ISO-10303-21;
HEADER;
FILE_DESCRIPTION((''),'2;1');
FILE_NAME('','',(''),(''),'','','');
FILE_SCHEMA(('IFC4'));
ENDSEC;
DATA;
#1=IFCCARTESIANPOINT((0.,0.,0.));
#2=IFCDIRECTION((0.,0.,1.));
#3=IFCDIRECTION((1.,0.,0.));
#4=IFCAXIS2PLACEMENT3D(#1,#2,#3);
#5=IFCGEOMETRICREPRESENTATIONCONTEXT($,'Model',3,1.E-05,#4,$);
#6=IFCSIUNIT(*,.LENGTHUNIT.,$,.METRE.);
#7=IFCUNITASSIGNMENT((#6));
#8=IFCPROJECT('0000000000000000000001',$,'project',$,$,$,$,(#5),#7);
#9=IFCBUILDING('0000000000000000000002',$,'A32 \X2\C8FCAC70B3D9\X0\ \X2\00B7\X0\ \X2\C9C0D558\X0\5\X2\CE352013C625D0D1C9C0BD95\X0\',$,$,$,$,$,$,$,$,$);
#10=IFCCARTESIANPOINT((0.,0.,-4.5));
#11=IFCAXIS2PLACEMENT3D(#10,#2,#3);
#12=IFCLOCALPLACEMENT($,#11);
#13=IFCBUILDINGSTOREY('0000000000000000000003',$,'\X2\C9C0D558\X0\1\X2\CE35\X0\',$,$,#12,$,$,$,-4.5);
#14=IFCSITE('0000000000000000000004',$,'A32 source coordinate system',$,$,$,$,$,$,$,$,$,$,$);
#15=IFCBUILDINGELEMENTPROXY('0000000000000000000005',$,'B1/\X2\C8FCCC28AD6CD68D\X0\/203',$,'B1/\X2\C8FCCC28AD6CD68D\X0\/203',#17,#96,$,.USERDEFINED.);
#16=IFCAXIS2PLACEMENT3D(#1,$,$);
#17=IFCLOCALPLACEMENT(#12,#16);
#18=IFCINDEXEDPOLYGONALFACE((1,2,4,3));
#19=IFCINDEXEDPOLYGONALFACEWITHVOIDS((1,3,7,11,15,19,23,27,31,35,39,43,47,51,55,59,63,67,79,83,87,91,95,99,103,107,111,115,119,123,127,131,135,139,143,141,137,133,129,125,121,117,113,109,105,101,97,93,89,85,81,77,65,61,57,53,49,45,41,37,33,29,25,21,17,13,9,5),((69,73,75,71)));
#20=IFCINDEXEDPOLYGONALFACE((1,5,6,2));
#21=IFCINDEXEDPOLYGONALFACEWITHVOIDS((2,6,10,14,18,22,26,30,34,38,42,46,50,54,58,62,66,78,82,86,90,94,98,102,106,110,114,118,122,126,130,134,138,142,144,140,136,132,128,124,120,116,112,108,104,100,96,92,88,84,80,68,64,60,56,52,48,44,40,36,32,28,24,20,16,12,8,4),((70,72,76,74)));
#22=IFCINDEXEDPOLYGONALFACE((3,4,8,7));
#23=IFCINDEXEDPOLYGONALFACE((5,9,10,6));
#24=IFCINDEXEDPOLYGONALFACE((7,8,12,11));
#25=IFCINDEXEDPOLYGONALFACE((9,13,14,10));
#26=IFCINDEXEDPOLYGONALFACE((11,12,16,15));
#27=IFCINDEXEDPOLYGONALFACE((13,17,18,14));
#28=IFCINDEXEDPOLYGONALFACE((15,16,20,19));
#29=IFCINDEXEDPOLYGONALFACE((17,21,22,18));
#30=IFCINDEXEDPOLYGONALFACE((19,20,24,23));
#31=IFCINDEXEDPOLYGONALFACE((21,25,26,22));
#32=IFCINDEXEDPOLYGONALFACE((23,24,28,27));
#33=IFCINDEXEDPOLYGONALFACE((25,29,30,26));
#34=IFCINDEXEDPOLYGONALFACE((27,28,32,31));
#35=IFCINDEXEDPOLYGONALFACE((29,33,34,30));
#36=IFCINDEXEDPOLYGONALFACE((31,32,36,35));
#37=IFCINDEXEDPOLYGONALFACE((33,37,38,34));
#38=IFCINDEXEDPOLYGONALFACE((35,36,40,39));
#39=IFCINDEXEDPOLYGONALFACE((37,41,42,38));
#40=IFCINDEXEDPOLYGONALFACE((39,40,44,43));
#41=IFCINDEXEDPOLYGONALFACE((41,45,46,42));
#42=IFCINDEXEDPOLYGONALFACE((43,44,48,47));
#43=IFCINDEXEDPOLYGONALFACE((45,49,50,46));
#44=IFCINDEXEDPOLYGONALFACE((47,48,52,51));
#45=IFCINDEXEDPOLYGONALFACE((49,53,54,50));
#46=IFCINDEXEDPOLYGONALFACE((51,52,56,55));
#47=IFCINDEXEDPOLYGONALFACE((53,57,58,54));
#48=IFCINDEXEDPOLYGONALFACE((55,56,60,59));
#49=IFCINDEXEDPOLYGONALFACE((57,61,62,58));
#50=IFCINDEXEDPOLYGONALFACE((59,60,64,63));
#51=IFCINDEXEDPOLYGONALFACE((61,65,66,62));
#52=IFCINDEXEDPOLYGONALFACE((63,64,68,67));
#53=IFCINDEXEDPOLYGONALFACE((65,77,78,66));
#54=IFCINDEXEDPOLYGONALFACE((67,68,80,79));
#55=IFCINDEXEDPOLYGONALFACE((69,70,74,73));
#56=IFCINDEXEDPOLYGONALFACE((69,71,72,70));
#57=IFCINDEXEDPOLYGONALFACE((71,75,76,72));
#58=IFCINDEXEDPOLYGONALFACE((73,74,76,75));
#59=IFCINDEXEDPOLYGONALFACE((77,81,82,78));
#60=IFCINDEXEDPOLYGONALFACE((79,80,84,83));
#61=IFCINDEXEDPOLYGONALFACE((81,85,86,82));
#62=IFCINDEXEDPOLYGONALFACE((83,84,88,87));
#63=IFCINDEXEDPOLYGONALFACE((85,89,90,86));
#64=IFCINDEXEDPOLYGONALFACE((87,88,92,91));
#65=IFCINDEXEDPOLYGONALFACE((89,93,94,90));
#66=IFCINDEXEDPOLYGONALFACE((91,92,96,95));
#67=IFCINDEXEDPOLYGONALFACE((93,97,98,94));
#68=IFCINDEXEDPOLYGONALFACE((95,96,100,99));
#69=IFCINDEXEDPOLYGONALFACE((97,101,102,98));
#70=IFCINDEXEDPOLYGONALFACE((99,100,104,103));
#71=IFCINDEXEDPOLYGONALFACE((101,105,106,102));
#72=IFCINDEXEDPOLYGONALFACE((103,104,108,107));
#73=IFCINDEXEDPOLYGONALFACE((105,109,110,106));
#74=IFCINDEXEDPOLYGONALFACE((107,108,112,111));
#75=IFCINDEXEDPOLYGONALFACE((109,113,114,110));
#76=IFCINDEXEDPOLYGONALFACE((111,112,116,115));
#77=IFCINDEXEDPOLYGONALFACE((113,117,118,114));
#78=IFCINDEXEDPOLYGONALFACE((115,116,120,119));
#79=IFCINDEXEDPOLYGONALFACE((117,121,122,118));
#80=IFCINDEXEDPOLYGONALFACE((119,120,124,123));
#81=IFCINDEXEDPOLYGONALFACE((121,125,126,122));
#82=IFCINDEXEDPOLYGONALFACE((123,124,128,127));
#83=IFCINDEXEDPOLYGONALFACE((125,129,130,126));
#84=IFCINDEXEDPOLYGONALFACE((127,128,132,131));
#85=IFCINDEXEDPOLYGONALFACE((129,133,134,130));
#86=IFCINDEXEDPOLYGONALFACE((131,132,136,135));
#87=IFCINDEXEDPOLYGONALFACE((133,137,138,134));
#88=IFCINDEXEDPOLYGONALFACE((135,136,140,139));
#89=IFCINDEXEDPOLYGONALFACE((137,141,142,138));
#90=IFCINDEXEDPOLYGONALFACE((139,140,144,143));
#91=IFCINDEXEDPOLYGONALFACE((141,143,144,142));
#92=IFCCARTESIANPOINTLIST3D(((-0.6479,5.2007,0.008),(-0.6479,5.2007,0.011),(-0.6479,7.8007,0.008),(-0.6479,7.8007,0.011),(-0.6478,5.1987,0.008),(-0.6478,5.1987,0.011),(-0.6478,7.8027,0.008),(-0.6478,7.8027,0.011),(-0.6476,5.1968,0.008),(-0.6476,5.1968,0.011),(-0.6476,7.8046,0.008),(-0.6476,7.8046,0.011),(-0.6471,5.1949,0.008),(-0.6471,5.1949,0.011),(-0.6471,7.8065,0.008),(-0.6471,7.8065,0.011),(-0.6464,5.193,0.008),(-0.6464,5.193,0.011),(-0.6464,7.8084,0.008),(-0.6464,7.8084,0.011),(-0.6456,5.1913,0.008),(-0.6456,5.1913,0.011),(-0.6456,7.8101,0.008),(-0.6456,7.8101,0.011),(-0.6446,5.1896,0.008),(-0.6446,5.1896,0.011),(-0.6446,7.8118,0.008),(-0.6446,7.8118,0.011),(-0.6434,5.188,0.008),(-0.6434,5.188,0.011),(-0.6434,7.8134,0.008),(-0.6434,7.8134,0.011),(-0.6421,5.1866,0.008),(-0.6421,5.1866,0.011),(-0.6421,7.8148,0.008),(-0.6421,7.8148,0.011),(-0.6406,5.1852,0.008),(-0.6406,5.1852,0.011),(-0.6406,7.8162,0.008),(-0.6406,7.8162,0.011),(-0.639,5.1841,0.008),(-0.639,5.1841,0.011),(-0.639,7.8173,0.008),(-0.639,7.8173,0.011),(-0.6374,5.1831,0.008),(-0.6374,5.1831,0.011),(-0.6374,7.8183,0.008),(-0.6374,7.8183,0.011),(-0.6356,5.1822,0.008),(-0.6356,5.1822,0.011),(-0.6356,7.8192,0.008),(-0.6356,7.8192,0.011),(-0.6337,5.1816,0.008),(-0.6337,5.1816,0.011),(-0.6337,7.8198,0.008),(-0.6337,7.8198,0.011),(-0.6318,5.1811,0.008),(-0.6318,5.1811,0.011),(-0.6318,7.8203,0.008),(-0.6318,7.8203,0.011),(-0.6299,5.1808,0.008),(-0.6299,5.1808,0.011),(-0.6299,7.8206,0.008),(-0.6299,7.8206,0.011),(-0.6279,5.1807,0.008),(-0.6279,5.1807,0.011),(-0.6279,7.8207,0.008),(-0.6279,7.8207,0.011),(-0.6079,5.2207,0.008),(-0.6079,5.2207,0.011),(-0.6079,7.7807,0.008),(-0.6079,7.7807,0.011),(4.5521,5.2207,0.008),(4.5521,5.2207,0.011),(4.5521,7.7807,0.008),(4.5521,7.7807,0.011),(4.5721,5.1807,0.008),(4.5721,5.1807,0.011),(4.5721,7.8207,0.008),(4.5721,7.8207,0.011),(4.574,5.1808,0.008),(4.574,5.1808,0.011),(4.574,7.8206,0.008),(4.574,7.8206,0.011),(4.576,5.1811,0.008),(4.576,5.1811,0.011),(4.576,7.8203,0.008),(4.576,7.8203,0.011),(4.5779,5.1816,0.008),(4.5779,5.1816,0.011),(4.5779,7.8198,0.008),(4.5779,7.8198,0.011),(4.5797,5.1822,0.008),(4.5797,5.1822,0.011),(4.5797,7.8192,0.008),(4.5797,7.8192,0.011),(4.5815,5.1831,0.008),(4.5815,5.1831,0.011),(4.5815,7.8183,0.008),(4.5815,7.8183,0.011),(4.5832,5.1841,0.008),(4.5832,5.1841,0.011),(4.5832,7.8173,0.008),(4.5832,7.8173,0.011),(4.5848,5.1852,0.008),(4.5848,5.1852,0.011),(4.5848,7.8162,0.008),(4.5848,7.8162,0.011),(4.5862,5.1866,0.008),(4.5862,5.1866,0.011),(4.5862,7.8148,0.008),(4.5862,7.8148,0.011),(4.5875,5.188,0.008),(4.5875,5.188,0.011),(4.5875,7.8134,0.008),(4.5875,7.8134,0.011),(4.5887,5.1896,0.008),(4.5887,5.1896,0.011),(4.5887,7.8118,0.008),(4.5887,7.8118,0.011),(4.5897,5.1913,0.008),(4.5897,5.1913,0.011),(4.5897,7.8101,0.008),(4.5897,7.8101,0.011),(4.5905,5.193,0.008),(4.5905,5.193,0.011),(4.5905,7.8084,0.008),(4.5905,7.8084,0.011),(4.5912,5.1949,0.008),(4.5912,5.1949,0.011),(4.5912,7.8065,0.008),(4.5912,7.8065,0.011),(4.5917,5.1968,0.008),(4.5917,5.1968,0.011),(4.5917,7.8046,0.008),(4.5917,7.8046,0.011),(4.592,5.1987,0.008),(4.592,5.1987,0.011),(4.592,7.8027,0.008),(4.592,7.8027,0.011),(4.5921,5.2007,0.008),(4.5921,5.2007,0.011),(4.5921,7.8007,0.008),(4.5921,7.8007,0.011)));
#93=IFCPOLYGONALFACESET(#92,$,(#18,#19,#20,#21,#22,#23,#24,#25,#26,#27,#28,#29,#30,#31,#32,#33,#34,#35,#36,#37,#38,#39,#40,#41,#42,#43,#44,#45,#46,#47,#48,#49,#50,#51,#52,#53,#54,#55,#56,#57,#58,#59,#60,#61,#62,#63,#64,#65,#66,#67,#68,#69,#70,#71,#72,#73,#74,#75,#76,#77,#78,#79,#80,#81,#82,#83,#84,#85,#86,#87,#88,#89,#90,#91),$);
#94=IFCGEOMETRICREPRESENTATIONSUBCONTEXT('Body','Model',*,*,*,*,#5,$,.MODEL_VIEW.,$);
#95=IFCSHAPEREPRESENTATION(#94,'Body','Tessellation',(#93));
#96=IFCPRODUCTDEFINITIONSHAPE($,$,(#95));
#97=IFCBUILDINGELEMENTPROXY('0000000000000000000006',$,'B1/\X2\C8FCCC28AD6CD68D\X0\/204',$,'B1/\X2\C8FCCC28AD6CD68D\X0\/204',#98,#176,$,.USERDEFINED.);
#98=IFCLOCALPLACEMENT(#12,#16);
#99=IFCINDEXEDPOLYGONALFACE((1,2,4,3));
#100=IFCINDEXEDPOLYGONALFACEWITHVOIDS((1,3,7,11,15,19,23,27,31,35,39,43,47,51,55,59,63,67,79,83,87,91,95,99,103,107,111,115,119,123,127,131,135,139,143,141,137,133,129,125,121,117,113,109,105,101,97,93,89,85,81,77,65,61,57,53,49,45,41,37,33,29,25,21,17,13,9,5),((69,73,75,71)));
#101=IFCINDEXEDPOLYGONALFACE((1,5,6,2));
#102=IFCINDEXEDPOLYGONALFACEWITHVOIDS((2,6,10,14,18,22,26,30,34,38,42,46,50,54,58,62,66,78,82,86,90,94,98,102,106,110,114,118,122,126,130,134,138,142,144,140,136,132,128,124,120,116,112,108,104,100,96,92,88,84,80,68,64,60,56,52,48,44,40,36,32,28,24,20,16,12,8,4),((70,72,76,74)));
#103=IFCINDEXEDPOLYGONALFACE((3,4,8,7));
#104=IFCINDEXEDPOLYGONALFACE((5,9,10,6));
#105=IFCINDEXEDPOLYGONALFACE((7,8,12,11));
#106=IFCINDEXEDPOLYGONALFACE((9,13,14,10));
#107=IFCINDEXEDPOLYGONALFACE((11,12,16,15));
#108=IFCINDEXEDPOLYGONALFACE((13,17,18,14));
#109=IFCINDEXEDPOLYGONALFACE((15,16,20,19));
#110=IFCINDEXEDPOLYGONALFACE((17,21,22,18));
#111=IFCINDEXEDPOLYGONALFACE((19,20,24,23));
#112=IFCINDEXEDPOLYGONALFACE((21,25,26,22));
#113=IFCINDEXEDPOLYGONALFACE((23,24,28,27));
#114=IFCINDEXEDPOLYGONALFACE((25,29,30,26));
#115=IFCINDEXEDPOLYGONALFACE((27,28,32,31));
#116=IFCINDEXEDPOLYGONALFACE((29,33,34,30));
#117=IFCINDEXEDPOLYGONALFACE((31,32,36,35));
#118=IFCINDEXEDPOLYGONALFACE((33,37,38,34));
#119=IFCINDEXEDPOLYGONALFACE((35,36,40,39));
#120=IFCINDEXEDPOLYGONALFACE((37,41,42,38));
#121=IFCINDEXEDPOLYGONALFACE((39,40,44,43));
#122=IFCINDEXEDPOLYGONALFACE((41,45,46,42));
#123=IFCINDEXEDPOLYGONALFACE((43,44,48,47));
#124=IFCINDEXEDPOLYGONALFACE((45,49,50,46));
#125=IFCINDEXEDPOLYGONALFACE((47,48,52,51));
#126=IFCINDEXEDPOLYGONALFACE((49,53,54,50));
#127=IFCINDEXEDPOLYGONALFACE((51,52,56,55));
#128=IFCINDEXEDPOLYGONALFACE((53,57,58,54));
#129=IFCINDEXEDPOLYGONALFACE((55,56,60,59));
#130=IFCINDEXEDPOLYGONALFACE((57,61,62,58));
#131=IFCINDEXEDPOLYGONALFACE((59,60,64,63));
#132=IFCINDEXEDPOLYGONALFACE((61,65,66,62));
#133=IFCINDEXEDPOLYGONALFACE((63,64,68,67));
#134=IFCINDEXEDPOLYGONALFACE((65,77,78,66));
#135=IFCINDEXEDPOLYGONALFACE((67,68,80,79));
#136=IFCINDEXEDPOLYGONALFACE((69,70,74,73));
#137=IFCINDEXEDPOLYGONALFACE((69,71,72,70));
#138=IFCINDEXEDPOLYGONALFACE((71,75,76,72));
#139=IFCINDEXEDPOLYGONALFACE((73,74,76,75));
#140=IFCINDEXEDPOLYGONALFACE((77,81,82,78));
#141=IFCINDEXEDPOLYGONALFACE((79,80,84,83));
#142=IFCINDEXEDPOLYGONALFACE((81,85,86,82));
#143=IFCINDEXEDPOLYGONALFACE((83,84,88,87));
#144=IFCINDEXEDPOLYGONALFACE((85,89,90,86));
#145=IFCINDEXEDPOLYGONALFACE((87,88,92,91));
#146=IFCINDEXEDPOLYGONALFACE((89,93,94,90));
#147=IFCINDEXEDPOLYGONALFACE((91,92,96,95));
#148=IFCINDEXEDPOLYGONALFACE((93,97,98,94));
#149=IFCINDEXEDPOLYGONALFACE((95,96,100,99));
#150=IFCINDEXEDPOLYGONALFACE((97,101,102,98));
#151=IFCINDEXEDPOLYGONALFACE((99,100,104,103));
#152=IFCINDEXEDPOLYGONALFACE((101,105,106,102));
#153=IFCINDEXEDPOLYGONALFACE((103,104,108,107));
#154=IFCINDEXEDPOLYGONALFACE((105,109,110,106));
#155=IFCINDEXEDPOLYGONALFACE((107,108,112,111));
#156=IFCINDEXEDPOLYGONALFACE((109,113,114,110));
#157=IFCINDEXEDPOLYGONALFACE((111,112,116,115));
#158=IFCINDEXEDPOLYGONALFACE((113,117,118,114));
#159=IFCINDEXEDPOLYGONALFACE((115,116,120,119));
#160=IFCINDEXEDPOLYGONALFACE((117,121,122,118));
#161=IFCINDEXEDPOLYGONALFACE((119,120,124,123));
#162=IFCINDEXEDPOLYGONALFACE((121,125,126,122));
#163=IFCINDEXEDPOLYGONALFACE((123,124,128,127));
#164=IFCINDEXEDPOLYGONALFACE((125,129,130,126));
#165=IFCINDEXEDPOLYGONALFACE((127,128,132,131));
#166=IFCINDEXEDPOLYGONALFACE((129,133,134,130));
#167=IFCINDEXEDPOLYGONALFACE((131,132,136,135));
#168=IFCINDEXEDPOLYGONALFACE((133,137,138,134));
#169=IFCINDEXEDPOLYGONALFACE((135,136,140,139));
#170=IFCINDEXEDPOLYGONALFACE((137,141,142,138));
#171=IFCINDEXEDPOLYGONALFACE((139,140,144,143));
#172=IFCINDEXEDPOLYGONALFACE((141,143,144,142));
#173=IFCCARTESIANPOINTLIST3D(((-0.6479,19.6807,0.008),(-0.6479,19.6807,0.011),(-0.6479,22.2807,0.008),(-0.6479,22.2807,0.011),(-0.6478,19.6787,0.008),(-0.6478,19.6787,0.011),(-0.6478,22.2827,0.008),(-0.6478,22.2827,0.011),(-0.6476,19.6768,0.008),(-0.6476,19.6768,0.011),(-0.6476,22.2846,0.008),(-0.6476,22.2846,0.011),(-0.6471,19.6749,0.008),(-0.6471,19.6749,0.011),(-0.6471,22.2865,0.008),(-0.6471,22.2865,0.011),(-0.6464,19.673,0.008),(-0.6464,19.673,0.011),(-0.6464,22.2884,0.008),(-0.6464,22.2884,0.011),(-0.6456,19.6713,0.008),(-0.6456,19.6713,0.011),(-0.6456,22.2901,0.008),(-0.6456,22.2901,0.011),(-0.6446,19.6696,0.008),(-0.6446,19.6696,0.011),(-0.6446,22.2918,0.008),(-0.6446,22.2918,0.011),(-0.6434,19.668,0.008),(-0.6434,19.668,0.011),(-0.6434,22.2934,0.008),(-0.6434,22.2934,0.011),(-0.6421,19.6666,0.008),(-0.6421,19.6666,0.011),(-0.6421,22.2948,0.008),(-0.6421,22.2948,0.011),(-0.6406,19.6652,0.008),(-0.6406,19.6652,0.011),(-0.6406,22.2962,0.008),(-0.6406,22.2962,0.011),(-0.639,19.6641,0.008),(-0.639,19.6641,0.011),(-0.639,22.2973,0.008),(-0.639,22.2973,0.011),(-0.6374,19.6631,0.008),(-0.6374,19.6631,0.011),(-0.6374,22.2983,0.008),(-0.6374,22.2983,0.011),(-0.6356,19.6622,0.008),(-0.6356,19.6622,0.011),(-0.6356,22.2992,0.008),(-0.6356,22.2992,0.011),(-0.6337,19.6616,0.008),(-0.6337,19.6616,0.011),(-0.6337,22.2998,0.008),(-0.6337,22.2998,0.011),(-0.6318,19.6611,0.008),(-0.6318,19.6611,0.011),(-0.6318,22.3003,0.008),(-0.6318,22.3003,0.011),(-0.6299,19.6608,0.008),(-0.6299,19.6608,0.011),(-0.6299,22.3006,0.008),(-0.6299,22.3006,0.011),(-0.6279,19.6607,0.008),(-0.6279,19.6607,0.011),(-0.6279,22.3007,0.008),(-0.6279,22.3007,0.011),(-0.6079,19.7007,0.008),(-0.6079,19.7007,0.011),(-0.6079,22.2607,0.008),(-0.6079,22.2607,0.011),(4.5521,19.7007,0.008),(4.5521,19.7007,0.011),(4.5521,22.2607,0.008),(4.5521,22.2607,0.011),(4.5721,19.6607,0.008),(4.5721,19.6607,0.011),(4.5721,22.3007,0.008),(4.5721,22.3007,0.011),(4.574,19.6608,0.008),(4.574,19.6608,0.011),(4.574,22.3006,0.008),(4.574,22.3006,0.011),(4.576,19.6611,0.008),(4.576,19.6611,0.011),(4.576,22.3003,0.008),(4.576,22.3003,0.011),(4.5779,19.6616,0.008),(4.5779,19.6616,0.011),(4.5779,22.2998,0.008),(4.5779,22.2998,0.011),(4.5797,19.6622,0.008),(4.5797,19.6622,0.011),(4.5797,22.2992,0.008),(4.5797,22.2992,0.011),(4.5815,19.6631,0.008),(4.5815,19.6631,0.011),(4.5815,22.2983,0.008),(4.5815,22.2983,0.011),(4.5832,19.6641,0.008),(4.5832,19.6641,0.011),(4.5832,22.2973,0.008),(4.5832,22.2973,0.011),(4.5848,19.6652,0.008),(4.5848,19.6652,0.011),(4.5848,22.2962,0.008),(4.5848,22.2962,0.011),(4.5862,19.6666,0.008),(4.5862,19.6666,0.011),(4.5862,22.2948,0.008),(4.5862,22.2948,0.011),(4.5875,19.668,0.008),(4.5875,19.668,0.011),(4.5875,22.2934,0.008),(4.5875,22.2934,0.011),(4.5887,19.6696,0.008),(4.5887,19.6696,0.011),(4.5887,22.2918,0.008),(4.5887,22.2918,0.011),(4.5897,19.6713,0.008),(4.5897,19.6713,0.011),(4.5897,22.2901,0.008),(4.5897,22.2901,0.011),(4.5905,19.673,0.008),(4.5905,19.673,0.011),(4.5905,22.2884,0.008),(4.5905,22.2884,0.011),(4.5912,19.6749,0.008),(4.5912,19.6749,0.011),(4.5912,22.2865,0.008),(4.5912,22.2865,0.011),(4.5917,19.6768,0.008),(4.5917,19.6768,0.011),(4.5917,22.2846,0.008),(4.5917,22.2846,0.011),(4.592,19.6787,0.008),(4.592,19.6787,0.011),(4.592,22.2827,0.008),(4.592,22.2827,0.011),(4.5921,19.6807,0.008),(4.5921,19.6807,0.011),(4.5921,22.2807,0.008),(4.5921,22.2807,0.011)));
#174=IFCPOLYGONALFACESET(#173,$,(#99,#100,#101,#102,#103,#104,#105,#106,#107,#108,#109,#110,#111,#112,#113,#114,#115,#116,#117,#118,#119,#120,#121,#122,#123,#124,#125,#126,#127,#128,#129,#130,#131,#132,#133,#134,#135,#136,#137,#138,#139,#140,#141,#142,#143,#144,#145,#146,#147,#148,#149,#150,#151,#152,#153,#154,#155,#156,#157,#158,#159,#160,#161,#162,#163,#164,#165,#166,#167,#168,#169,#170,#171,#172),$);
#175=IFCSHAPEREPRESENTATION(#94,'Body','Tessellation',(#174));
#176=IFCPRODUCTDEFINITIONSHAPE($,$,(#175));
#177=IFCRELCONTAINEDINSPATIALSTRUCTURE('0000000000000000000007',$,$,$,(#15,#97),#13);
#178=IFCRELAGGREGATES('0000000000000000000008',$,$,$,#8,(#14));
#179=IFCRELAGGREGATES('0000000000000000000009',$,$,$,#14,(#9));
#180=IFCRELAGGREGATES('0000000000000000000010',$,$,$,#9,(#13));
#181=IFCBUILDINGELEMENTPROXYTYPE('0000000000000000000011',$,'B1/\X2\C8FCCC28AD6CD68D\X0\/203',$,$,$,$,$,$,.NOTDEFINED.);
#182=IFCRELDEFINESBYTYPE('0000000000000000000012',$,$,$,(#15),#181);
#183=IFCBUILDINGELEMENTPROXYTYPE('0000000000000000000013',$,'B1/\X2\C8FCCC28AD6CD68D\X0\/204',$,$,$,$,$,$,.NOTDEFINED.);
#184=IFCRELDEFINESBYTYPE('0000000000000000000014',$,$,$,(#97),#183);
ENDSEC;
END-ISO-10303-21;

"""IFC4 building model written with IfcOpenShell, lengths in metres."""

from ifc_helpers import new_model, si_unit, frame, origin, origin_with_axes, place, context, subcontext, project, spatial, polyline, outline, extrude, source, transform, mapped, type_object, type_shapes, element, save


model = new_model("IFC4")

# Units and contexts
model_context = context("Model", 3, precision=1e-05, world=origin_with_axes())
body_context = subcontext(model_context, "Body", "Model", "MODEL_VIEW")
ifc_project = project(units=[si_unit("LENGTHUNIT", "METRE")], contexts=[model_context])

# Site, building, storey
site = spatial("IfcSite", under=ifc_project, Name="A32 source coordinate system")
building = spatial("IfcBuilding", under=site, Name="A32 주거동 · 지하5층–옥탑지붕")
storey_placement = place(None, frame((0.0, 0.0, -4.5), z_axis=(0.0, 0.0, 1.0), x_axis=(1.0, 0.0, 0.0)))
storey = spatial("IfcBuildingStorey", under=building, at=storey_placement, Name="지하1층", Elevation=-4.5)

# Building element proxies
building_element_proxy_type_1 = type_object("IfcBuildingElementProxyType", Name="B1/주차구획/203", PredefinedType="NOTDEFINED")
shared_shape_1 = source(origin(), body_context, "Body", "SweptSolid", [
    extrude(outline(polyline([(-0.6279, 5.1807), (-0.6299, 5.1808), (-0.6318, 5.1811), (-0.6337, 5.1816), (-0.6356, 5.1822), (-0.6374, 5.1831), (-0.639, 5.1841), (-0.6406, 5.1852), (-0.6421, 5.1866), (-0.6434, 5.188), (-0.6446, 5.1896), (-0.6456, 5.1913), (-0.6464, 5.193), (-0.6471, 5.1949), (-0.6476, 5.1968), (-0.6478, 5.1987), (-0.6479, 5.2007), (-0.6479, 7.8007), (-0.6478, 7.8027), (-0.6476, 7.8046), (-0.6471, 7.8065), (-0.6464, 7.8084), (-0.6456, 7.8101), (-0.6446, 7.8118), (-0.6434, 7.8134), (-0.6421, 7.8148), (-0.6406, 7.8162), (-0.639, 7.8173), (-0.6374, 7.8183), (-0.6356, 7.8192), (-0.6337, 7.8198), (-0.6318, 7.8203), (-0.6299, 7.8206), (-0.6279, 7.8207), (4.5721, 7.8207), (4.574, 7.8206), (4.576, 7.8203), (4.5779, 7.8198), (4.5797, 7.8192), (4.5815, 7.8183), (4.5832, 7.8173), (4.5848, 7.8162), (4.5862, 7.8148), (4.5875, 7.8134), (4.5887, 7.8118), (4.5897, 7.8101), (4.5905, 7.8084), (4.5912, 7.8065), (4.5917, 7.8046), (4.592, 7.8027), (4.5921, 7.8007), (4.5921, 5.2007), (4.592, 5.1987), (4.5917, 5.1968), (4.5912, 5.1949), (4.5905, 5.193), (4.5897, 5.1913), (4.5887, 5.1896), (4.5875, 5.188), (4.5862, 5.1866), (4.5848, 5.1852), (4.5832, 5.1841), (4.5815, 5.1831), (4.5797, 5.1822), (4.5779, 5.1816), (4.576, 5.1811), (4.574, 5.1808), (4.5721, 5.1807), (-0.6279, 5.1807)]), holes=[polyline([(-0.6079, 5.2207), (4.5521, 5.2207), (4.5521, 7.7807), (-0.6079, 7.7807), (-0.6079, 5.2207)])]), frame((0.0, 0.0, 0.008)), (0.0, 0.0, 1.0), 0.003),
])
type_shapes(building_element_proxy_type_1, [shared_shape_1])
proxy_1_placement = place(storey_placement, origin_with_axes())
element("IfcBuildingElementProxy", 1, at=proxy_1_placement, inside=storey, type_object=building_element_proxy_type_1, Name="B1/주차구획/203", ObjectType="B1/주차구획/203", PredefinedType="USERDEFINED", context=body_context, shape_type="MappedRepresentation", body=[
    mapped(shared_shape_1, transform((0.0, 0.0, 0.0), scale=1.0)),
])
building_element_proxy_type_2 = type_object("IfcBuildingElementProxyType", Name="B1/주차구획/204", PredefinedType="NOTDEFINED")
shared_shape_2 = source(origin(), body_context, "Body", "SweptSolid", [
    extrude(outline(polyline([(-0.6279, 19.6607), (-0.6299, 19.6608), (-0.6318, 19.6611), (-0.6337, 19.6616), (-0.6356, 19.6622), (-0.6374, 19.6631), (-0.639, 19.6641), (-0.6406, 19.6652), (-0.6421, 19.6666), (-0.6434, 19.668), (-0.6446, 19.6696), (-0.6456, 19.6713), (-0.6464, 19.673), (-0.6471, 19.6749), (-0.6476, 19.6768), (-0.6478, 19.6787), (-0.6479, 19.6807), (-0.6479, 22.2807), (-0.6478, 22.2827), (-0.6476, 22.2846), (-0.6471, 22.2865), (-0.6464, 22.2884), (-0.6456, 22.2901), (-0.6446, 22.2918), (-0.6434, 22.2934), (-0.6421, 22.2948), (-0.6406, 22.2962), (-0.639, 22.2973), (-0.6374, 22.2983), (-0.6356, 22.2992), (-0.6337, 22.2998), (-0.6318, 22.3003), (-0.6299, 22.3006), (-0.6279, 22.3007), (4.5721, 22.3007), (4.574, 22.3006), (4.576, 22.3003), (4.5779, 22.2998), (4.5797, 22.2992), (4.5815, 22.2983), (4.5832, 22.2973), (4.5848, 22.2962), (4.5862, 22.2948), (4.5875, 22.2934), (4.5887, 22.2918), (4.5897, 22.2901), (4.5905, 22.2884), (4.5912, 22.2865), (4.5917, 22.2846), (4.592, 22.2827), (4.5921, 22.2807), (4.5921, 19.6807), (4.592, 19.6787), (4.5917, 19.6768), (4.5912, 19.6749), (4.5905, 19.673), (4.5897, 19.6713), (4.5887, 19.6696), (4.5875, 19.668), (4.5862, 19.6666), (4.5848, 19.6652), (4.5832, 19.6641), (4.5815, 19.6631), (4.5797, 19.6622), (4.5779, 19.6616), (4.576, 19.6611), (4.574, 19.6608), (4.5721, 19.6607), (-0.6279, 19.6607)]), holes=[polyline([(-0.6079, 19.7007), (4.5521, 19.7007), (4.5521, 22.2607), (-0.6079, 22.2607), (-0.6079, 19.7007)])]), frame((0.0, 0.0, 0.008)), (0.0, 0.0, 1.0), 0.003),
])
type_shapes(building_element_proxy_type_2, [shared_shape_2])
proxy_2_placement = place(storey_placement, origin_with_axes())
element("IfcBuildingElementProxy", 2, at=proxy_2_placement, inside=storey, type_object=building_element_proxy_type_2, Name="B1/주차구획/204", ObjectType="B1/주차구획/204", PredefinedType="USERDEFINED", context=body_context, shape_type="MappedRepresentation", body=[
    mapped(shared_shape_2, transform((0.0, 0.0, 0.0), scale=1.0)),
])

save(model, "model.ifc")
